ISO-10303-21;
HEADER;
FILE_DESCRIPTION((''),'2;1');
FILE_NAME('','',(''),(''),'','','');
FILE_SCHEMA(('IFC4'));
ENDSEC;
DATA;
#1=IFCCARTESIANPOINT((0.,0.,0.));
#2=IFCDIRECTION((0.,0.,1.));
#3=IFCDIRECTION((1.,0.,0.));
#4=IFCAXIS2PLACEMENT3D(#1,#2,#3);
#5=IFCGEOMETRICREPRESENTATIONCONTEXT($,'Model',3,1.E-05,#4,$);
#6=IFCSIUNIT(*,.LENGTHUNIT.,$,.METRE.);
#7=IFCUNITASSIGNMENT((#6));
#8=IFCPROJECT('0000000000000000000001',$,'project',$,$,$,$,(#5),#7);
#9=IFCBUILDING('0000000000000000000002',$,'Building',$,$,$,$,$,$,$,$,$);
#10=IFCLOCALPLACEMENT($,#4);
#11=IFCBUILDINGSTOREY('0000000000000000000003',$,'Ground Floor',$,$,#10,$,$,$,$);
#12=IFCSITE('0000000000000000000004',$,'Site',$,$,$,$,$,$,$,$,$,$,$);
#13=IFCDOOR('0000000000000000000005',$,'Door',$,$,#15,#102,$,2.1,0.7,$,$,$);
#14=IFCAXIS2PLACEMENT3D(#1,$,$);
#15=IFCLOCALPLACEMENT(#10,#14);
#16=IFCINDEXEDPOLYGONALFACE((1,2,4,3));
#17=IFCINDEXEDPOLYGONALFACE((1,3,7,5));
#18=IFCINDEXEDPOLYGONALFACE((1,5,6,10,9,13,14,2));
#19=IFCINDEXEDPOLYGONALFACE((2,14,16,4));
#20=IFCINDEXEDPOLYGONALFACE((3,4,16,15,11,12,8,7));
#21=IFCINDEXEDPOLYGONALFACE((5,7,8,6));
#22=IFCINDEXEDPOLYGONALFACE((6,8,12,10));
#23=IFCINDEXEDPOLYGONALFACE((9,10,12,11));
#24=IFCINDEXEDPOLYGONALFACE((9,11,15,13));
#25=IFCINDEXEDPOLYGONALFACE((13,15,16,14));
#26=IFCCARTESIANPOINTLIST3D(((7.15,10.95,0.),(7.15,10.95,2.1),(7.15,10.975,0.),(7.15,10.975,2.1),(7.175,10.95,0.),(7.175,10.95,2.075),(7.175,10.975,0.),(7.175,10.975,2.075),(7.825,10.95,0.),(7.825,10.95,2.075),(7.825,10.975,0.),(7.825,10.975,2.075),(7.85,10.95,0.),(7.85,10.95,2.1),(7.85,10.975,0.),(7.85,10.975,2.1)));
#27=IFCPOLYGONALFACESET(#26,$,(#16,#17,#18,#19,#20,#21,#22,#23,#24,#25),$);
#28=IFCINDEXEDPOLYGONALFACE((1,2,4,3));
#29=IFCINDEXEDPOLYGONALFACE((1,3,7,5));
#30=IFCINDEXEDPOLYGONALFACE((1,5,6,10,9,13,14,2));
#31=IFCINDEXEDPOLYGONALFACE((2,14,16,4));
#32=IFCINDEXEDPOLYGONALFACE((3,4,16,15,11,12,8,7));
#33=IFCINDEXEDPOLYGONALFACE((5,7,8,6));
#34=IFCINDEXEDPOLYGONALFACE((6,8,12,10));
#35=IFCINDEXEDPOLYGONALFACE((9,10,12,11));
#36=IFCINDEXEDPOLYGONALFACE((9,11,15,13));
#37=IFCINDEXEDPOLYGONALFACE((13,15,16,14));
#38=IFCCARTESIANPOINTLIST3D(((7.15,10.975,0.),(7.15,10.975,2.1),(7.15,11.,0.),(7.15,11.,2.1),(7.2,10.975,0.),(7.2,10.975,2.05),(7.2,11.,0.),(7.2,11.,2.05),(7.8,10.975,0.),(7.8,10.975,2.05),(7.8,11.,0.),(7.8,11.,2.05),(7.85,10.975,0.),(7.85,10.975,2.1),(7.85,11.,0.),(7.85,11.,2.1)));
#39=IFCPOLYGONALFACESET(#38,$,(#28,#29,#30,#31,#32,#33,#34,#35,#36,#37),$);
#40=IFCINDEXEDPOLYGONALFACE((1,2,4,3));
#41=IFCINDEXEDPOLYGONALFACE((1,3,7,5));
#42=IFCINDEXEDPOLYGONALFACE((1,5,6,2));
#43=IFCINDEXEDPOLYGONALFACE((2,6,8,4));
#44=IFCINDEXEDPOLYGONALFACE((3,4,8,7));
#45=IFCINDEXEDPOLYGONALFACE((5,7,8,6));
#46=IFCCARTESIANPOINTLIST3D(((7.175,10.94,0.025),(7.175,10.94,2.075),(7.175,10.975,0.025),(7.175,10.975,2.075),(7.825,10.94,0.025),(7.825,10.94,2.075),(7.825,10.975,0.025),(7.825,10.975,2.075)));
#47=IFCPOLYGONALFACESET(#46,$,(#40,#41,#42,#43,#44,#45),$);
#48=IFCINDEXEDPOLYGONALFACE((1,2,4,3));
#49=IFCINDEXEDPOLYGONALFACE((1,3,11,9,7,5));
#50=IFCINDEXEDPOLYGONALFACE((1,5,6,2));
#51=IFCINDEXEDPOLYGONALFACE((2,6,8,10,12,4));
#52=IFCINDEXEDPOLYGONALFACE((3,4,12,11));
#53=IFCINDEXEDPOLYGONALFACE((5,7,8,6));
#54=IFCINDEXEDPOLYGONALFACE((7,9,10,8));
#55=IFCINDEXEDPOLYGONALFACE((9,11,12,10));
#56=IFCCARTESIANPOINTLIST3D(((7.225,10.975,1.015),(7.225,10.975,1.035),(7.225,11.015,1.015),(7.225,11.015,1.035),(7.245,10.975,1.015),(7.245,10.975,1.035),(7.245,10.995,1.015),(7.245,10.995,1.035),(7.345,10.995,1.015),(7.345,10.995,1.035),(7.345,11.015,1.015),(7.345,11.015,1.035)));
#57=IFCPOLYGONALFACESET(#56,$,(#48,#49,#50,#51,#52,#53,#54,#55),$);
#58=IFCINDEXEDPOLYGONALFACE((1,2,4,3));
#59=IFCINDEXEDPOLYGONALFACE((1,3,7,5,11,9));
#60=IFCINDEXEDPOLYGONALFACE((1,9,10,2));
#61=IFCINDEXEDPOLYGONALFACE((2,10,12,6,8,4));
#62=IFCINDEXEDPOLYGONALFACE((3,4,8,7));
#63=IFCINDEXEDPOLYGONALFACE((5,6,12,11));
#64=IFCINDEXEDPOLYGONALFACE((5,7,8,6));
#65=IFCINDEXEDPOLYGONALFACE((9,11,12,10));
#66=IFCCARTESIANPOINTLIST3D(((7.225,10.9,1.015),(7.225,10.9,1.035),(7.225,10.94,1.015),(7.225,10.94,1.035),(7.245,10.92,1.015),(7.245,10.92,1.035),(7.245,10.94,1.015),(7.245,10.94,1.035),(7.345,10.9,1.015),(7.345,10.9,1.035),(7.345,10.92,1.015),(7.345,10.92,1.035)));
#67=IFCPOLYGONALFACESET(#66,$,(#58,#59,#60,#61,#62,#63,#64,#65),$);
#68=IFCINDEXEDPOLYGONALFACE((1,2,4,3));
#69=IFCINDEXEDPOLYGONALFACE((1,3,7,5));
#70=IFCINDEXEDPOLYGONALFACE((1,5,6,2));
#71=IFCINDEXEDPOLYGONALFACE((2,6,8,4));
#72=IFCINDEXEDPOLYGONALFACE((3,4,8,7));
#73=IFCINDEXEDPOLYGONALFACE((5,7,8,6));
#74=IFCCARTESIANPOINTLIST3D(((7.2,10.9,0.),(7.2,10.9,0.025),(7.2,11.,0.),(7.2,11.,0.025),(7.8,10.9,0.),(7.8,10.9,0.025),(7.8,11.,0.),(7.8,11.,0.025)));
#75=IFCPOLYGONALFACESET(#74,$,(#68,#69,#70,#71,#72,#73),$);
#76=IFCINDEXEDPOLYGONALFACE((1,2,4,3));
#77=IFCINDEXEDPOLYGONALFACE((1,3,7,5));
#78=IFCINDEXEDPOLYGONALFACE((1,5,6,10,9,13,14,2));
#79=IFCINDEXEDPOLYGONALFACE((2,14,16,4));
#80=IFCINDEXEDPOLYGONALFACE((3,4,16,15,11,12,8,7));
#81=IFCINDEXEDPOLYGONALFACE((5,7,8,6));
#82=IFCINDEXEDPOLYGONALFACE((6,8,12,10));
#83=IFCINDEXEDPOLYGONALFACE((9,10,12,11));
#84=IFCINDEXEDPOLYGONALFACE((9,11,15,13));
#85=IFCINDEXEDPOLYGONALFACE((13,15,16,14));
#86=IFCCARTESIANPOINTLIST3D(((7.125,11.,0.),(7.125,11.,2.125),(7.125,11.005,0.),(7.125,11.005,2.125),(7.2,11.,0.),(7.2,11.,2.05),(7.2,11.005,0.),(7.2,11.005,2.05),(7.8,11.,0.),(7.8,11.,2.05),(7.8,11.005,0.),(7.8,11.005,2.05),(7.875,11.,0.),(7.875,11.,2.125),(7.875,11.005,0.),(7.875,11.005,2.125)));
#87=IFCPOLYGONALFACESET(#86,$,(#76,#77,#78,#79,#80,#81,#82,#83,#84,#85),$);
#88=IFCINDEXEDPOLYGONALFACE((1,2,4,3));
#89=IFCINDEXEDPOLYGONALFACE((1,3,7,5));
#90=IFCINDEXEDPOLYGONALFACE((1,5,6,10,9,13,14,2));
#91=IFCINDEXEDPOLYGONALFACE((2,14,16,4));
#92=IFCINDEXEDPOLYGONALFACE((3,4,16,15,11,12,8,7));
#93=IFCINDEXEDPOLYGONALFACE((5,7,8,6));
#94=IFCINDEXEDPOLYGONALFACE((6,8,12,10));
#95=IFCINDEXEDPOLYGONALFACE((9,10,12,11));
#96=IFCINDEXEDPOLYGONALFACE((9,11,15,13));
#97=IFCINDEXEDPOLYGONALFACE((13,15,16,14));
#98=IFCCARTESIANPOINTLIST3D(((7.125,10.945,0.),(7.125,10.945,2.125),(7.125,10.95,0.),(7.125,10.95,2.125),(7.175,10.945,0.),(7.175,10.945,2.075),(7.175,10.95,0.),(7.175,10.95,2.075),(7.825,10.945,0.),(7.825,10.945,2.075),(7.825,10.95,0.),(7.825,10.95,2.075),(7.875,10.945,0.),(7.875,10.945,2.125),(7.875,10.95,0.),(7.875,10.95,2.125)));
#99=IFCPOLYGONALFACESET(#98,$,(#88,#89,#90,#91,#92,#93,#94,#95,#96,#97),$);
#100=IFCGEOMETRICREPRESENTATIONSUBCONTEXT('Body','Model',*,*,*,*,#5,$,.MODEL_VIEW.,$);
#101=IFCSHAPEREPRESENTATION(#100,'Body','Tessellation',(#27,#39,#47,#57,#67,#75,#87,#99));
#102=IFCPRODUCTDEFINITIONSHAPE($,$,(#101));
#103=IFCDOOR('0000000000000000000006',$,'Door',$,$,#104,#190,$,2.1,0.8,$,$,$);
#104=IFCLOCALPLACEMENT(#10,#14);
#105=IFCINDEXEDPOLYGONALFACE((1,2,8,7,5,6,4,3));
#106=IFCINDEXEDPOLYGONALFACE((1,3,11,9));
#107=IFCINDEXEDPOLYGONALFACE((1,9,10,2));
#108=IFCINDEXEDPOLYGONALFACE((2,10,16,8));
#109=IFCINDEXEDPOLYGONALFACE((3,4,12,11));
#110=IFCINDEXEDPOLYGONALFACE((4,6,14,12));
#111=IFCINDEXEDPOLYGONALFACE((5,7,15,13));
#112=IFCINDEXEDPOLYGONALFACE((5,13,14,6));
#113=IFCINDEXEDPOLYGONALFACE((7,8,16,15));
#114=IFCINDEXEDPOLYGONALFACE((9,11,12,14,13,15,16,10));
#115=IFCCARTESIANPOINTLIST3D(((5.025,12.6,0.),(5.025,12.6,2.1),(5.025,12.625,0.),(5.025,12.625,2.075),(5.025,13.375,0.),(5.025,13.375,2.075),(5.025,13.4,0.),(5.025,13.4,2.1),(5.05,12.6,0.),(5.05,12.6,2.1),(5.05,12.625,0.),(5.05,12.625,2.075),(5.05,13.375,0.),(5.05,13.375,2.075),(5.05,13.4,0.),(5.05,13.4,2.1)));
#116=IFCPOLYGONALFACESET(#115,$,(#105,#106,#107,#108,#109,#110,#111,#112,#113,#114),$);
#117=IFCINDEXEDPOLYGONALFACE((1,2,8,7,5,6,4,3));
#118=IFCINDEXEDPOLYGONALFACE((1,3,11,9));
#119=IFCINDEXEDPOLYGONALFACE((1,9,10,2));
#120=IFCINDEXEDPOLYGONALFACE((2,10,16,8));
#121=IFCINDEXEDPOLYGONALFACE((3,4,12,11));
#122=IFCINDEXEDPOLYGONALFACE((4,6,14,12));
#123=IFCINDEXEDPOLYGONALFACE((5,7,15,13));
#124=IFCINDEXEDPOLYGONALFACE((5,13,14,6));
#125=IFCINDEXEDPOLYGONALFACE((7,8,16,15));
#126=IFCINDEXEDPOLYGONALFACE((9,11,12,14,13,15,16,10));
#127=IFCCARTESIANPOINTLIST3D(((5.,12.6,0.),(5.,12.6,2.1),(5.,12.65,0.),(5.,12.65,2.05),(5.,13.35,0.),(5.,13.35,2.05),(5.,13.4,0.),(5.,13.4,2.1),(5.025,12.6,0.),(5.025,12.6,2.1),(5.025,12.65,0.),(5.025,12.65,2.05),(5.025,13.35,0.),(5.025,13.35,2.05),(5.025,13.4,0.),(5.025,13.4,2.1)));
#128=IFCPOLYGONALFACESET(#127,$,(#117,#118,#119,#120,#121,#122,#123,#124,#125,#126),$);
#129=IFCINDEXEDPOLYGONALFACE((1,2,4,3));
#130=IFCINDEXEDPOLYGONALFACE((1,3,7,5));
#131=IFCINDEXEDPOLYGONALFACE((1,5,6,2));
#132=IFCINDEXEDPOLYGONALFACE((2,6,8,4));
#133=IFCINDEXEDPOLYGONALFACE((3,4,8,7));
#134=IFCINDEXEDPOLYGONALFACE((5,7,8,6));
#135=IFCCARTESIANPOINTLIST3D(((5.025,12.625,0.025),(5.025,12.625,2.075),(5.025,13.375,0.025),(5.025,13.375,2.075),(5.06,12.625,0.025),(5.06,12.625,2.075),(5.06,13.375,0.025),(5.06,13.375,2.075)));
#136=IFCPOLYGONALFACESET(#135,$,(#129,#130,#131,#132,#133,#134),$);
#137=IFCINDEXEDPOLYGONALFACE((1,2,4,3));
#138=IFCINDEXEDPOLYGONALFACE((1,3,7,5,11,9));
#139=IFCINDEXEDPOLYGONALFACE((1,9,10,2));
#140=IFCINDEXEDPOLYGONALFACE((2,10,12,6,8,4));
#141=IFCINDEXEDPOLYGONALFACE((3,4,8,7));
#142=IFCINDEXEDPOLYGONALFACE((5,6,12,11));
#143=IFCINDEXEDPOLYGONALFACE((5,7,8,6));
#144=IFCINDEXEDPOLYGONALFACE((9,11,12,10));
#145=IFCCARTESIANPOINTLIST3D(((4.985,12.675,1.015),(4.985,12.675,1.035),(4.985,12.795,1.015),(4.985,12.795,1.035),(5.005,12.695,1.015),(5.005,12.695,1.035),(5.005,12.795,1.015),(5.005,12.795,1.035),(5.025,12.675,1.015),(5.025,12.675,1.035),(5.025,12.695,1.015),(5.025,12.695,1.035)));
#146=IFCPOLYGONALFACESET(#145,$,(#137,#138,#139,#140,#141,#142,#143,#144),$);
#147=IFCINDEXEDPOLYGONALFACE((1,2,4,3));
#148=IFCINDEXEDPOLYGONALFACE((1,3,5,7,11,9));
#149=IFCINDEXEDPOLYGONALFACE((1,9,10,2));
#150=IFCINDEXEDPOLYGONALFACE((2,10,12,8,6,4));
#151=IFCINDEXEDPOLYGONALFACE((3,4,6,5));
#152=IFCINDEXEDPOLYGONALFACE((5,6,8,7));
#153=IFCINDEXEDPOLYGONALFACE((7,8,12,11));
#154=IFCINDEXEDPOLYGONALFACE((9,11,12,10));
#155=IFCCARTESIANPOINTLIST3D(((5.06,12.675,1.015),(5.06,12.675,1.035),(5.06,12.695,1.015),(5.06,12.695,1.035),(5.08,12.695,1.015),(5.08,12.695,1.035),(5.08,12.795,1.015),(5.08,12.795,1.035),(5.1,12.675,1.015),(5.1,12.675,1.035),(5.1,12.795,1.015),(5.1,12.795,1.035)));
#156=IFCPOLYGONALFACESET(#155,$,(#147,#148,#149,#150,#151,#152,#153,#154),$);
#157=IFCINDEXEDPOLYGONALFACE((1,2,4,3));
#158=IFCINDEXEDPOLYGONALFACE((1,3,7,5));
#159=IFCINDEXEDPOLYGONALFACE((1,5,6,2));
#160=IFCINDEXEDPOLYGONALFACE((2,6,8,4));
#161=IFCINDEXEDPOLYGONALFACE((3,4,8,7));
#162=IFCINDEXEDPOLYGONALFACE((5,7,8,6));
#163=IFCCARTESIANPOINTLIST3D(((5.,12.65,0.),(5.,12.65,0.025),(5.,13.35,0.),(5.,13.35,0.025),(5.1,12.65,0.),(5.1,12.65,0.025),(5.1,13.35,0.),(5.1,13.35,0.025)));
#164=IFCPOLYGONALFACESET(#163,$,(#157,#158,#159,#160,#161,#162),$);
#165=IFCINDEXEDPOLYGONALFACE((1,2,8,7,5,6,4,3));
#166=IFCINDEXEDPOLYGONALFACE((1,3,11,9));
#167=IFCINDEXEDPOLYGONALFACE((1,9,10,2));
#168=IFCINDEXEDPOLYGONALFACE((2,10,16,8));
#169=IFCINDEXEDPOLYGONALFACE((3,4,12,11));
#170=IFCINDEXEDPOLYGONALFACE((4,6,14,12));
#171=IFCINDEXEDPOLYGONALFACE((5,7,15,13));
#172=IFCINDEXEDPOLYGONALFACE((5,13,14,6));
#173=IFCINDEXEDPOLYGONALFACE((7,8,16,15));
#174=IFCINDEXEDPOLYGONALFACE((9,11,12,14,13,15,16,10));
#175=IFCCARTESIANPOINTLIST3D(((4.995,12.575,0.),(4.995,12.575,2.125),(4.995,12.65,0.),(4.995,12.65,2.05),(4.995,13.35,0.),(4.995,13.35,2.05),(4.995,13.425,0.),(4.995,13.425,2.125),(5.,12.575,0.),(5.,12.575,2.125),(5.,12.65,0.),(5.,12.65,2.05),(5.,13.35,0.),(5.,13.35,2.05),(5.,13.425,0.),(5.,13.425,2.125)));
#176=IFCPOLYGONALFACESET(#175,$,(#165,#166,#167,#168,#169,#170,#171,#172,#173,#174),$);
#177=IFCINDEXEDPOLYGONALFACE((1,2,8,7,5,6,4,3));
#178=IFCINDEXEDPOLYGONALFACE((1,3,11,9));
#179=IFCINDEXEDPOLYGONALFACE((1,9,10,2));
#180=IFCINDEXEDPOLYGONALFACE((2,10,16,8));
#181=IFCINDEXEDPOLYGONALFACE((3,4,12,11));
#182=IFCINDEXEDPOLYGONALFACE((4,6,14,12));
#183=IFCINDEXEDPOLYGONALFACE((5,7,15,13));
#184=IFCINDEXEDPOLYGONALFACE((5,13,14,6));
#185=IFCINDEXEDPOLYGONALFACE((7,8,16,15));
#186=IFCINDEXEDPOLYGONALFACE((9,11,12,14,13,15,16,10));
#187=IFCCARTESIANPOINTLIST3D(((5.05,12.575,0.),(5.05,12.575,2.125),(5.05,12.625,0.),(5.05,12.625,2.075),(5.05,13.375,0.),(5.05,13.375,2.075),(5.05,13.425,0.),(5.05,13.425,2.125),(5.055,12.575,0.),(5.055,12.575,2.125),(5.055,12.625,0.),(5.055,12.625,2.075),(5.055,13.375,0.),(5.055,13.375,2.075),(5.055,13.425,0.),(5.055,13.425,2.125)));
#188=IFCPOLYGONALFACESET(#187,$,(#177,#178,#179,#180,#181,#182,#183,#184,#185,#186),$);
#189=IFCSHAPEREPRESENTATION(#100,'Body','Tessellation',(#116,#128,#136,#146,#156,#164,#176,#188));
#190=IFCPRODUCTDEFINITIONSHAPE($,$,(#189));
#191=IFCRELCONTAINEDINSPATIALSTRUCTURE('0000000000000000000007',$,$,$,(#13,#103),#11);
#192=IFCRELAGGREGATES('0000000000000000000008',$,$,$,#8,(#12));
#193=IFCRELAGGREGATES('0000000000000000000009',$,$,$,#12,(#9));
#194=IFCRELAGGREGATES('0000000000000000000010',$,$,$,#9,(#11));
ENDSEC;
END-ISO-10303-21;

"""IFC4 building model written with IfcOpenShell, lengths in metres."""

from ifc_helpers import new_model, si_unit, frame, origin_with_axes, place, context, subcontext, project, spatial, line, indexed_curve, outline, extrude, element, save


model = new_model("IFC4")

# Units and contexts
model_context = context("Model", 3, precision=1e-05, world=origin_with_axes())
body_context = subcontext(model_context, "Body", "Model", "MODEL_VIEW")
ifc_project = project(units=[si_unit("LENGTHUNIT", "METRE")], contexts=[model_context])

# Site, building, storey
site = spatial("IfcSite", under=ifc_project, Name="Site")
building = spatial("IfcBuilding", under=site, Name="Building")
storey_placement = place(None, origin_with_axes())
storey = spatial("IfcBuildingStorey", under=building, at=storey_placement, Name="Ground Floor")

# Doors
door_1_placement = place(storey_placement, frame((7.85, 11.0, 0.0), z_axis=(0.0, 0.0, 1.0), x_axis=(-1.0, 0.0, 0.0)))
element("IfcDoor", 1, at=door_1_placement, inside=storey, Name="Door", OverallHeight=2.1, OverallWidth=0.7, context=body_context, shape_type="SweptSolid", body=[
    extrude(outline(indexed_curve([(0.0, 0.0), (0.0, 2.1), (0.7, 2.1), (0.7, 0.0), (0.675, 0.0), (0.675, 2.075), (0.025, 2.075), (0.025, 0.0)], segments=[line(1, 2, 3, 4, 5, 6, 7, 8, 1)])), frame((0.0, 0.025, 0.0), z_axis=(0.0, -1.0, 0.0), x_axis=(1.0, 0.0, 0.0)), (0.0, 0.0, -1.0), 0.025),
    extrude(outline(indexed_curve([(0.0, 0.0), (0.0, 2.1), (0.7, 2.1), (0.7, 0.0), (0.65, 0.0), (0.65, 2.05), (0.05, 2.05), (0.05, 0.0)], segments=[line(1, 2, 3, 4, 5, 6, 7, 8, 1)])), frame((0.0, 0.0, 0.0), z_axis=(0.0, -1.0, 0.0), x_axis=(1.0, 0.0, 0.0)), (0.0, 0.0, -1.0), 0.025),
    extrude(outline(indexed_curve([(0.0, 0.0), (0.65, 0.0), (0.65, 0.035), (0.0, 0.035)], segments=[line(1, 2, 3, 4, 1)])), frame((0.025, 0.025, 0.025), z_axis=(0.0, 0.0, 1.0), x_axis=(1.0, 0.0, 0.0)), (0.0, 0.0, 1.0), 2.05),
    extrude(outline(indexed_curve([(0.0, 0.0), (0.0, -0.04), (-0.12, -0.04), (-0.12, -0.02), (-0.02, -0.02), (-0.02, 0.0)], segments=[line(1, 2, 3, 4, 5, 6, 1)])), frame((0.625, 0.025, 1.015), z_axis=(0.0, 0.0, 1.0), x_axis=(1.0, 0.0, 0.0)), (0.0, 0.0, 1.0), 0.02),
    extrude(outline(indexed_curve([(0.0, 0.0), (0.0, 0.04), (-0.12, 0.04), (-0.12, 0.02), (-0.02, 0.02), (-0.02, 0.0)], segments=[line(1, 2, 3, 4, 5, 6, 1)])), frame((0.625, 0.06, 1.015), z_axis=(0.0, 0.0, 1.0), x_axis=(1.0, 0.0, 0.0)), (0.0, 0.0, 1.0), 0.02),
    extrude(outline(indexed_curve([(0.0, 0.0), (0.6, 0.0), (0.6, 0.1), (0.0, 0.1)], segments=[line(1, 2, 3, 4, 1)])), frame((0.05, 0.0, 0.0), z_axis=(0.0, 0.0, 1.0), x_axis=(1.0, 0.0, 0.0)), (0.0, 0.0, 1.0), 0.025),
    extrude(outline(indexed_curve([(0.0, 0.0), (0.0, 2.125), (0.75, 2.125), (0.75, 0.0), (0.675, 0.0), (0.675, 2.05), (0.075, 2.05), (0.075, 0.0)], segments=[line(1, 2, 3, 4, 5, 6, 7, 8, 1)])), frame((-0.025, -0.005, 0.0), z_axis=(0.0, -1.0, 0.0), x_axis=(1.0, 0.0, 0.0)), (0.0, 0.0, -1.0), 0.005),
    extrude(outline(indexed_curve([(0.0, 0.0), (0.0, 2.125), (0.75, 2.125), (0.75, 0.0), (0.7, 0.0), (0.7, 2.075), (0.05, 2.075), (0.05, 0.0)], segments=[line(1, 2, 3, 4, 5, 6, 7, 8, 1)])), frame((-0.025, 0.05, 0.0), z_axis=(0.0, -1.0, 0.0), x_axis=(1.0, 0.0, 0.0)), (0.0, 0.0, -1.0), 0.005),
])
door_2_placement = place(storey_placement, frame((5.0, 13.4, 0.0), z_axis=(0.0, 0.0, 1.0), x_axis=(0.0, -1.0, 0.0)))
element("IfcDoor", 2, at=door_2_placement, inside=storey, Name="Door", OverallHeight=2.1, OverallWidth=0.8, context=body_context, shape_type="SweptSolid", body=[
    extrude(outline(indexed_curve([(0.0, 0.0), (0.0, 2.1), (0.8, 2.1), (0.8, 0.0), (0.775, 0.0), (0.775, 2.075), (0.025, 2.075), (0.025, 0.0)], segments=[line(1, 2, 3, 4, 5, 6, 7, 8, 1)])), frame((0.0, 0.025, 0.0), z_axis=(0.0, -1.0, 0.0), x_axis=(1.0, 0.0, 0.0)), (0.0, 0.0, -1.0), 0.025),
    extrude(outline(indexed_curve([(0.0, 0.0), (0.0, 2.1), (0.8, 2.1), (0.8, 0.0), (0.75, 0.0), (0.75, 2.05), (0.05, 2.05), (0.05, 0.0)], segments=[line(1, 2, 3, 4, 5, 6, 7, 8, 1)])), frame((0.0, 0.0, 0.0), z_axis=(0.0, -1.0, 0.0), x_axis=(1.0, 0.0, 0.0)), (0.0, 0.0, -1.0), 0.025),
    extrude(outline(indexed_curve([(0.0, 0.0), (0.75, 0.0), (0.75, 0.035), (0.0, 0.035)], segments=[line(1, 2, 3, 4, 1)])), frame((0.025, 0.025, 0.025), z_axis=(0.0, 0.0, 1.0), x_axis=(1.0, 0.0, 0.0)), (0.0, 0.0, 1.0), 2.05),
    extrude(outline(indexed_curve([(0.0, 0.0), (0.0, -0.04), (-0.12, -0.04), (-0.12, -0.02), (-0.02, -0.02), (-0.02, 0.0)], segments=[line(1, 2, 3, 4, 5, 6, 1)])), frame((0.725, 0.025, 1.015), z_axis=(0.0, 0.0, 1.0), x_axis=(1.0, 0.0, 0.0)), (0.0, 0.0, 1.0), 0.02),
    extrude(outline(indexed_curve([(0.0, 0.0), (0.0, 0.04), (-0.12, 0.04), (-0.12, 0.02), (-0.02, 0.02), (-0.02, 0.0)], segments=[line(1, 2, 3, 4, 5, 6, 1)])), frame((0.725, 0.06, 1.015), z_axis=(0.0, 0.0, 1.0), x_axis=(1.0, 0.0, 0.0)), (0.0, 0.0, 1.0), 0.02),
    extrude(outline(indexed_curve([(0.0, 0.0), (0.7, 0.0), (0.7, 0.1), (0.0, 0.1)], segments=[line(1, 2, 3, 4, 1)])), frame((0.05, 0.0, 0.0), z_axis=(0.0, 0.0, 1.0), x_axis=(1.0, 0.0, 0.0)), (0.0, 0.0, 1.0), 0.025),
    extrude(outline(indexed_curve([(0.0, 0.0), (0.0, 2.125), (0.85, 2.125), (0.85, 0.0), (0.775, 0.0), (0.775, 2.05), (0.075, 2.05), (0.075, 0.0)], segments=[line(1, 2, 3, 4, 5, 6, 7, 8, 1)])), frame((-0.025, -0.005, 0.0), z_axis=(0.0, -1.0, 0.0), x_axis=(1.0, 0.0, 0.0)), (0.0, 0.0, -1.0), 0.005),
    extrude(outline(indexed_curve([(0.0, 0.0), (0.0, 2.125), (0.85, 2.125), (0.85, 0.0), (0.8, 0.0), (0.8, 2.075), (0.05, 2.075), (0.05, 0.0)], segments=[line(1, 2, 3, 4, 5, 6, 7, 8, 1)])), frame((-0.025, 0.05, 0.0), z_axis=(0.0, -1.0, 0.0), x_axis=(1.0, 0.0, 0.0)), (0.0, 0.0, -1.0), 0.005),
])

save(model, "model.ifc")
